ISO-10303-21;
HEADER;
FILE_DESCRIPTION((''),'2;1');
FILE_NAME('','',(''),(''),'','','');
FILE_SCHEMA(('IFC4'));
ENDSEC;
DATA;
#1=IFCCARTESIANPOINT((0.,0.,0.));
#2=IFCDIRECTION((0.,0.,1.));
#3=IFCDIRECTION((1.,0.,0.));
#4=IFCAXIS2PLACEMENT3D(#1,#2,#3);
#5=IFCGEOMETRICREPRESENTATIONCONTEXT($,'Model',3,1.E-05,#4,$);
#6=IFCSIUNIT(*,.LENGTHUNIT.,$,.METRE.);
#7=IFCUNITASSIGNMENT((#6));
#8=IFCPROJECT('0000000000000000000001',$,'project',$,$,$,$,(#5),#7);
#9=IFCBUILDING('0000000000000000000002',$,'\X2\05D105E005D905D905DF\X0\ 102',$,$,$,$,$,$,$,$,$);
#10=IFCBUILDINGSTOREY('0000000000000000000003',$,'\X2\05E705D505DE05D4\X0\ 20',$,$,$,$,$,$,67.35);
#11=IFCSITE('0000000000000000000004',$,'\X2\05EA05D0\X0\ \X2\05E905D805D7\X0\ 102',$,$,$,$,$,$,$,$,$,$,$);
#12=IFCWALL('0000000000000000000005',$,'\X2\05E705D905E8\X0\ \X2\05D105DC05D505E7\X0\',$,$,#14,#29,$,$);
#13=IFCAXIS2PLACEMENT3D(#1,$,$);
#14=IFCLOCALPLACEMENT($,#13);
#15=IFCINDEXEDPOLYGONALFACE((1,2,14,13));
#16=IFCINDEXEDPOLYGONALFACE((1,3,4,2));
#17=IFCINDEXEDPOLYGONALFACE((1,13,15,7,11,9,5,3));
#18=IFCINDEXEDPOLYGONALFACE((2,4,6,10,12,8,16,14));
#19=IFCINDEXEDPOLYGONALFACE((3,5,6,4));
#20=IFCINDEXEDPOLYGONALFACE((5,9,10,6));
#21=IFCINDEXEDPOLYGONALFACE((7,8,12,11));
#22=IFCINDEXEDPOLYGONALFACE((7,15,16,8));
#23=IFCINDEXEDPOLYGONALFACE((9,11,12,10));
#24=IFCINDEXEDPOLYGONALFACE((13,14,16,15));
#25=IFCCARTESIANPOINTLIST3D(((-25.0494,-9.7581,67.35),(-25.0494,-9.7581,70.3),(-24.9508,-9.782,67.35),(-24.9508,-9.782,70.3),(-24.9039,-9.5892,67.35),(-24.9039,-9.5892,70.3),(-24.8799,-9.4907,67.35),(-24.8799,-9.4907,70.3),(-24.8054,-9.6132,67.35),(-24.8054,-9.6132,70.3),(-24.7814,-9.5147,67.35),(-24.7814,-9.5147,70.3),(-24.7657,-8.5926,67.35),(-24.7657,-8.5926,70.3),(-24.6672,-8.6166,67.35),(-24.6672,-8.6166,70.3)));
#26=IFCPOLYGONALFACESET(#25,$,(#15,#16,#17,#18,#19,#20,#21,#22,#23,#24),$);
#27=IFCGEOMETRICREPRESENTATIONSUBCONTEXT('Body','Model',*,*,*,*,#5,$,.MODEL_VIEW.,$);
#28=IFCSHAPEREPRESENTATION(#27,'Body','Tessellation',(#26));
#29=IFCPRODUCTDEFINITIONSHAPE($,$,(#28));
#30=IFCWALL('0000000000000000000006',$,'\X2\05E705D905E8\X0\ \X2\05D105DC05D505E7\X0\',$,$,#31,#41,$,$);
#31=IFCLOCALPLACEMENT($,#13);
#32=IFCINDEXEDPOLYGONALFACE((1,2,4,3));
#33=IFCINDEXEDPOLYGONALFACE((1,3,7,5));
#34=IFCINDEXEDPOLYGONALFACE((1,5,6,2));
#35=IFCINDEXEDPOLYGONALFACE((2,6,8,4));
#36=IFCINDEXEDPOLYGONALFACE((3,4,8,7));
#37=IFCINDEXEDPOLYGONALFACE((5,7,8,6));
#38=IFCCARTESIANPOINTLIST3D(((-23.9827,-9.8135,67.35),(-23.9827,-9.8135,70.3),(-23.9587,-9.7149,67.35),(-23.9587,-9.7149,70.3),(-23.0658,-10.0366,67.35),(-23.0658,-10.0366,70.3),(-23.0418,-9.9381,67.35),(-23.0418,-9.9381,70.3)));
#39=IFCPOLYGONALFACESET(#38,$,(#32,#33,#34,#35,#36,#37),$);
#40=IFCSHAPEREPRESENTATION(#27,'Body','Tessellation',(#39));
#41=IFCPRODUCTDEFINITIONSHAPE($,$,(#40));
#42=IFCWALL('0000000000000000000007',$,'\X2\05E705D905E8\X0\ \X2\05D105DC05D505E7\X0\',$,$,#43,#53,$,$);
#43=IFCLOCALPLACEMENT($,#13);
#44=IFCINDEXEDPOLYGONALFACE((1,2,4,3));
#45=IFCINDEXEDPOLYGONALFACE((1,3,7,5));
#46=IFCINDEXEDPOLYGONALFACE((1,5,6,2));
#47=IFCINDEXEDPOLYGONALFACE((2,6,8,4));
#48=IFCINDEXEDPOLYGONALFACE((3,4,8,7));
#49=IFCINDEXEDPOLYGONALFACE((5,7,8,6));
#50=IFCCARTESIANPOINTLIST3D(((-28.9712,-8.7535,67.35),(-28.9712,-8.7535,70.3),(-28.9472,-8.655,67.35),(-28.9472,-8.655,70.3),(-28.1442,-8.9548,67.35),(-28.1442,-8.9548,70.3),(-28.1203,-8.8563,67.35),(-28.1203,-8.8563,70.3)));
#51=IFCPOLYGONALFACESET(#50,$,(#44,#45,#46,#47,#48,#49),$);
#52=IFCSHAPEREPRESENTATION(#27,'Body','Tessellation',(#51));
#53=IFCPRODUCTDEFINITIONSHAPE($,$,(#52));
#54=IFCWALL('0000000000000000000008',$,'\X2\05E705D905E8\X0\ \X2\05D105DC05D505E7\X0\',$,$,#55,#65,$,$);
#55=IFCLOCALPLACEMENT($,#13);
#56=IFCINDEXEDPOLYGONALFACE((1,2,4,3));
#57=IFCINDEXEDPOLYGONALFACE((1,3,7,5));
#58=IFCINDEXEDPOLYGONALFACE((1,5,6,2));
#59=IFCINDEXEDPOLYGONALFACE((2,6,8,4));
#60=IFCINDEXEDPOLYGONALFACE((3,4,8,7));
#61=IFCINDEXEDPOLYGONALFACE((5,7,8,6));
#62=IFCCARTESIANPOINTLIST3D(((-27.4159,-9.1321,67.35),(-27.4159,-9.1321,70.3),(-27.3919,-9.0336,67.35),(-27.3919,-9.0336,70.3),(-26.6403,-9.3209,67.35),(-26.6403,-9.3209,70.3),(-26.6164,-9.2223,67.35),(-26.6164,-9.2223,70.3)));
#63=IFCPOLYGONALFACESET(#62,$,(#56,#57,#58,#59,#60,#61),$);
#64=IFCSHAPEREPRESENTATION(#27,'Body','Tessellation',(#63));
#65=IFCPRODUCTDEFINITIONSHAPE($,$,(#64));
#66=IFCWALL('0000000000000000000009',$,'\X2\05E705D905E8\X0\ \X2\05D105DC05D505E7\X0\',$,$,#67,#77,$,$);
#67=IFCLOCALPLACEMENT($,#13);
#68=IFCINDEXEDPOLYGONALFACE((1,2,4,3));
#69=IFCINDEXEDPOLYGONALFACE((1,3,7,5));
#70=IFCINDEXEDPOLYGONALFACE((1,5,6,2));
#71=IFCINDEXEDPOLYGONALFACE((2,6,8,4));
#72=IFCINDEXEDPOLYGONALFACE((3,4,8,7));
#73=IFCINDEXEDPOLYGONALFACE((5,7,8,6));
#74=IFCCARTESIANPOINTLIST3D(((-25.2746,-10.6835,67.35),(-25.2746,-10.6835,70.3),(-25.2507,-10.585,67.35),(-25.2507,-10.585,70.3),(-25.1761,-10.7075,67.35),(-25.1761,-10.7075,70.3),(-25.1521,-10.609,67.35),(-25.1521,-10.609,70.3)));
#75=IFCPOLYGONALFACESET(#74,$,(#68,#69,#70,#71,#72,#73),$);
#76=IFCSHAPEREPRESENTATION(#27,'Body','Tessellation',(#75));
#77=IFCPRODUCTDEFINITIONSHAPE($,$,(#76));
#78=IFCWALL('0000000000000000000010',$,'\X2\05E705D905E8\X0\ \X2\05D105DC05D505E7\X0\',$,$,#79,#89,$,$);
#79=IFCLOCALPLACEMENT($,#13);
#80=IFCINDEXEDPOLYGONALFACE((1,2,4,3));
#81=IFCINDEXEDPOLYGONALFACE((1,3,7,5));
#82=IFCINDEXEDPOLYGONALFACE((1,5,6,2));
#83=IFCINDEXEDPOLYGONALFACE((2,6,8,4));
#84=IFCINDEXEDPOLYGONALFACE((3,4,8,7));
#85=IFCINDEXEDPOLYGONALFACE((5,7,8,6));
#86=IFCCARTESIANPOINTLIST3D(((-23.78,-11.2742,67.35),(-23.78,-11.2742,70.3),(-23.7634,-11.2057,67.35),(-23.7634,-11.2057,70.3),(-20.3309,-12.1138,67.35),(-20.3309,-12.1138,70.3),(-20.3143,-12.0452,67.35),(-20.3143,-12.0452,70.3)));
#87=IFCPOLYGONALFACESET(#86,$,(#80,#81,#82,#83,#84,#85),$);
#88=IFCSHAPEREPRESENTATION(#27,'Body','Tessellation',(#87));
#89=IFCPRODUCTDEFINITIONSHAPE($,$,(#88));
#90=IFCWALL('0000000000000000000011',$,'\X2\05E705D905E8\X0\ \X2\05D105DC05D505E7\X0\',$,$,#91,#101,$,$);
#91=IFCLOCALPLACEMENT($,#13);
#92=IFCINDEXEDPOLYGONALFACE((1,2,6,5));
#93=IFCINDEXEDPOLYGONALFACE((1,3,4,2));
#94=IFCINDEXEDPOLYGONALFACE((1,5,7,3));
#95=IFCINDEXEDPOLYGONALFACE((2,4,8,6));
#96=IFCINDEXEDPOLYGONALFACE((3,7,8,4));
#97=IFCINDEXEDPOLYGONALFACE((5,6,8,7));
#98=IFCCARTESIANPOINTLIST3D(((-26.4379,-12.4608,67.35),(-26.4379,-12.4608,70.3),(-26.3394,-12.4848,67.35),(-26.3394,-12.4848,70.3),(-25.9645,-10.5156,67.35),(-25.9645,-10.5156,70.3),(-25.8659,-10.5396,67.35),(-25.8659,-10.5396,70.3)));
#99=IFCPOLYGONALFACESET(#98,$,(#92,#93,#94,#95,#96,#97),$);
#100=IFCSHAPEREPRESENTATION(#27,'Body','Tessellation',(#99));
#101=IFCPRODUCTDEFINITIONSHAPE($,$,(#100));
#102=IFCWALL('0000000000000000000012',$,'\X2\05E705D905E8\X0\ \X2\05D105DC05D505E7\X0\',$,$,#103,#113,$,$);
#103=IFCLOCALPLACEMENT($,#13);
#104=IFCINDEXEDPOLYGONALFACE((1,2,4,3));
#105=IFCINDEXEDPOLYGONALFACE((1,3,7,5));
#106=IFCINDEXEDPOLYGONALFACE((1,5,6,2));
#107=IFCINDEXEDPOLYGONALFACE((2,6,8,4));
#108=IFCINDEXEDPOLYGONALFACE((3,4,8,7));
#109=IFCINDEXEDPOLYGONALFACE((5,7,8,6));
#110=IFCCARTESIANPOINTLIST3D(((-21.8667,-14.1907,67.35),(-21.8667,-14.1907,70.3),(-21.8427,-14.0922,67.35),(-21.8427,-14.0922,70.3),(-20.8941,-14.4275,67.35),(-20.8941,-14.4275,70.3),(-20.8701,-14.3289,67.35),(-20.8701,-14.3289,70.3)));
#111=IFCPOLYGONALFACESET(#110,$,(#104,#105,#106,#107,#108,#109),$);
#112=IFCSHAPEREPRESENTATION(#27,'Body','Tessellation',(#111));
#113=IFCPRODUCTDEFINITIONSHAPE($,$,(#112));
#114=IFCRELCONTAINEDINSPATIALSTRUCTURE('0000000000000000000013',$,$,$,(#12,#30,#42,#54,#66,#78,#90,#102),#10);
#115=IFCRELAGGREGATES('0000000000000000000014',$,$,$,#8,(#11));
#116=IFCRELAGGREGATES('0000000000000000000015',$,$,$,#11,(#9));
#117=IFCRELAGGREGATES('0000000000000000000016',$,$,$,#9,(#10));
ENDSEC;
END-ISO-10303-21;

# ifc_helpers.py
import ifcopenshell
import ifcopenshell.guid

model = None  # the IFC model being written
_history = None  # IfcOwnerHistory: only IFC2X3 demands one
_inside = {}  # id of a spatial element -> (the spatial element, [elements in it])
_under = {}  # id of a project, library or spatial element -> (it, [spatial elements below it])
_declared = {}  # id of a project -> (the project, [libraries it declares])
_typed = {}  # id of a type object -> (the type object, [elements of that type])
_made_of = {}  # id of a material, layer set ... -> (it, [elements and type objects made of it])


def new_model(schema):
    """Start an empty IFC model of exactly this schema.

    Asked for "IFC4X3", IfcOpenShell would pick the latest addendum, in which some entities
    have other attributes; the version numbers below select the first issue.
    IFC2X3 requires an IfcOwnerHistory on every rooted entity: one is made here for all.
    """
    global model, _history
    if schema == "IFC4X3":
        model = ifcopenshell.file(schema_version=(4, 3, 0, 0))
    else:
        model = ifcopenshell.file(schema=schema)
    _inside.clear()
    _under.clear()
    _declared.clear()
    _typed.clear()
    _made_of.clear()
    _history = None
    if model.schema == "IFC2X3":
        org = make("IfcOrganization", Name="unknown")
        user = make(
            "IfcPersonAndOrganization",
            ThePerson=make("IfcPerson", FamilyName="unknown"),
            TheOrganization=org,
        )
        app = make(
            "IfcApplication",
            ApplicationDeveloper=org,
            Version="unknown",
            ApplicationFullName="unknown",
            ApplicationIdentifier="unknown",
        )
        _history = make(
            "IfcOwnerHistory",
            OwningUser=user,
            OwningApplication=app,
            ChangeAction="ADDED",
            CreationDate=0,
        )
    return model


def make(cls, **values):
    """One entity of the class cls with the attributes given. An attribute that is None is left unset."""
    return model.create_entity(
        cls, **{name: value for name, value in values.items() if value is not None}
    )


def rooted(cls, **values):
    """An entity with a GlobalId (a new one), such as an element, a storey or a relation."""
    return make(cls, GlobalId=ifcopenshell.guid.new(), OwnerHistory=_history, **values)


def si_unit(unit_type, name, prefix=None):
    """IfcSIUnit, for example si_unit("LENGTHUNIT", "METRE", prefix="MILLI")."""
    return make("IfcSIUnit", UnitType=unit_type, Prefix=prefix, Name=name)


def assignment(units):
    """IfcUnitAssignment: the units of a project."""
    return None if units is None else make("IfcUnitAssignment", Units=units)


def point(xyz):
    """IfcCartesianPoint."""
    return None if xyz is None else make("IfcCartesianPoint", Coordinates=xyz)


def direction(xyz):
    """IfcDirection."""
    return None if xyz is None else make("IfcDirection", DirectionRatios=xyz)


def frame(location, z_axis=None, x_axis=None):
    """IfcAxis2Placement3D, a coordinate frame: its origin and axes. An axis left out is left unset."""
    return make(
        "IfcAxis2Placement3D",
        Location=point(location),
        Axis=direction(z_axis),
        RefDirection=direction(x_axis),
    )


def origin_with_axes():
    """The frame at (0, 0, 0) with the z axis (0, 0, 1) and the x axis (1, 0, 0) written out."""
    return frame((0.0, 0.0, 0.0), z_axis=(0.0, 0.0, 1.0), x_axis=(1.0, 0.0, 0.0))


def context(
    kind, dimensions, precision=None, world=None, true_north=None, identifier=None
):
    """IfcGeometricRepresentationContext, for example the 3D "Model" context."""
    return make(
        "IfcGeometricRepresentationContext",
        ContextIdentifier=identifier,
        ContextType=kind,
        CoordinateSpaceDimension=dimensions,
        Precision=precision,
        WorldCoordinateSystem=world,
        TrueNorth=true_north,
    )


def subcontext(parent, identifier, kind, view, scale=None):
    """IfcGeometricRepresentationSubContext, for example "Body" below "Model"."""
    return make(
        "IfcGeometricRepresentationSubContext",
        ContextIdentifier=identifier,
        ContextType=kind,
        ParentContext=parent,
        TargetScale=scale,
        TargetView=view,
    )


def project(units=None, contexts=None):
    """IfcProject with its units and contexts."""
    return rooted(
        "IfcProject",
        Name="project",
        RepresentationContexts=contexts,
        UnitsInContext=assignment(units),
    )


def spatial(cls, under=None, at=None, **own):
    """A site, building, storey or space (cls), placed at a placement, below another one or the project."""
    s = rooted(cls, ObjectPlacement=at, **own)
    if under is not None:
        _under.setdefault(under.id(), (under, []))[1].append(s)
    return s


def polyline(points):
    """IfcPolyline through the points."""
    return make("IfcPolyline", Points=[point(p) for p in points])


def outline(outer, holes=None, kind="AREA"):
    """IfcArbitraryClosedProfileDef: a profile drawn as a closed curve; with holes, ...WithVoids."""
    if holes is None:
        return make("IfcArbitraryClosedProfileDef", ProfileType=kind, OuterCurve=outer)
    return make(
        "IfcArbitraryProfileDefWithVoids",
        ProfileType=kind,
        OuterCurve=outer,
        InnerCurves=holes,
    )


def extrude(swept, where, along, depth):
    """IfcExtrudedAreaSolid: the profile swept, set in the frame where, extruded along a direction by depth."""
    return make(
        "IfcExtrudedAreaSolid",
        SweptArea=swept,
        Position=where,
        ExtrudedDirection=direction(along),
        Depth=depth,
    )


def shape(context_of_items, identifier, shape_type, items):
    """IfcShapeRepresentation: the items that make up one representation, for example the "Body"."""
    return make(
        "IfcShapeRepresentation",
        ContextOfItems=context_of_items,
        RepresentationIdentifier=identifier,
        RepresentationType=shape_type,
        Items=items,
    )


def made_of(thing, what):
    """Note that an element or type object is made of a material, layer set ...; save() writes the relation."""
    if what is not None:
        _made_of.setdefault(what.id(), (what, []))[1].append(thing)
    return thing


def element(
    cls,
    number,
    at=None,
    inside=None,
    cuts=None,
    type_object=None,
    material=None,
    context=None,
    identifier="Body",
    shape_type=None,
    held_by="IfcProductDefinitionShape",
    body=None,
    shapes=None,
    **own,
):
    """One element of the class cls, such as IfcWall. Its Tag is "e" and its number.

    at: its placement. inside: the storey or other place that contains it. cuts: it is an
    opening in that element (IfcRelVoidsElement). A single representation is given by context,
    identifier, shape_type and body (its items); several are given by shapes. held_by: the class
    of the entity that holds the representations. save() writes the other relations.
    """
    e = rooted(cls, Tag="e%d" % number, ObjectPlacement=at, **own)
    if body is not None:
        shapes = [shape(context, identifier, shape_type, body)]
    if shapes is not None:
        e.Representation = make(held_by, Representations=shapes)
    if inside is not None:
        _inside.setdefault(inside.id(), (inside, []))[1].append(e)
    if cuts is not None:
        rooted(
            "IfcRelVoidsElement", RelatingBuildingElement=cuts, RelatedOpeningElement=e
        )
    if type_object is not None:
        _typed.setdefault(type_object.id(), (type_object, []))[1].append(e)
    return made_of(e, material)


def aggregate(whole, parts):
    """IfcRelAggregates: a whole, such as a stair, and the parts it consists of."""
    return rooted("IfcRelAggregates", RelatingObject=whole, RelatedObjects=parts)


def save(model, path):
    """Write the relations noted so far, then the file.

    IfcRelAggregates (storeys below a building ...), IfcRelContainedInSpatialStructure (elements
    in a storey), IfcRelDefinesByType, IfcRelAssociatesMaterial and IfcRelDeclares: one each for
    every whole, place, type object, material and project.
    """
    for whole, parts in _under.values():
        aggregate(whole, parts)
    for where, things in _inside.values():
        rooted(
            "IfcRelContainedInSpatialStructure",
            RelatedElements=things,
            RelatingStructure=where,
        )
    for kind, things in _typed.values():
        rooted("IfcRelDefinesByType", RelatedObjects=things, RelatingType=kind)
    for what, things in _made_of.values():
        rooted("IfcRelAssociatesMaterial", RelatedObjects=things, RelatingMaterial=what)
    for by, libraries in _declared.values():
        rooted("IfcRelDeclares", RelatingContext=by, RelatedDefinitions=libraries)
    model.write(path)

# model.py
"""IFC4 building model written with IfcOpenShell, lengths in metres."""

from ifc_helpers import new_model, si_unit, frame, origin_with_axes, context, subcontext, project, spatial, polyline, outline, extrude, element, save


model = new_model("IFC4")

# Units and contexts
model_context = context("Model", 3, precision=1e-05, world=origin_with_axes())
body_context = subcontext(model_context, "Body", "Model", "MODEL_VIEW")
ifc_project = project(units=[si_unit("LENGTHUNIT", "METRE")], contexts=[model_context])

# Site, building, storey
site = spatial("IfcSite", under=ifc_project, Name="תא שטח 102")
building = spatial("IfcBuilding", under=site, Name="בניין 102")
storey = spatial("IfcBuildingStorey", under=building, Name="קומה 20", Elevation=67.35)

# Walls
element("IfcWall", 1, inside=storey, Name="קיר בלוק", context=body_context, shape_type="SweptSolid", body=[
    extrude(outline(polyline([(-24.8054, -9.6132), (-24.7814, -9.5147), (-24.8799, -9.4907), (-24.6672, -8.6166), (-24.7657, -8.5926), (-25.0494, -9.7581), (-24.9508, -9.782), (-24.9039, -9.5892), (-24.8054, -9.6132)])), frame((0.0, 0.0, 67.35)), (0.0, 0.0, 1.0), 2.95),
])
element("IfcWall", 2, inside=storey, Name="קיר בלוק", context=body_context, shape_type="SweptSolid", body=[
    extrude(outline(polyline([(-23.9587, -9.7149), (-23.9827, -9.8135), (-23.0658, -10.0366), (-23.0418, -9.9381), (-23.9587, -9.7149)])), frame((0.0, 0.0, 67.35)), (0.0, 0.0, 1.0), 2.95),
])
element("IfcWall", 3, inside=storey, Name="קיר בלוק", context=body_context, shape_type="SweptSolid", body=[
    extrude(outline(polyline([(-28.9712, -8.7535), (-28.1442, -8.9548), (-28.1203, -8.8563), (-28.9472, -8.655), (-28.9712, -8.7535)])), frame((0.0, 0.0, 67.35)), (0.0, 0.0, 1.0), 2.95),
])
element("IfcWall", 4, inside=storey, Name="קיר בלוק", context=body_context, shape_type="SweptSolid", body=[
    extrude(outline(polyline([(-27.3919, -9.0336), (-27.4159, -9.1321), (-26.6403, -9.3209), (-26.6164, -9.2223), (-27.3919, -9.0336)])), frame((0.0, 0.0, 67.35)), (0.0, 0.0, 1.0), 2.95),
])
element("IfcWall", 5, inside=storey, Name="קיר בלוק", context=body_context, shape_type="SweptSolid", body=[
    extrude(outline(polyline([(-25.1521, -10.609), (-25.2507, -10.585), (-25.2746, -10.6835), (-25.1761, -10.7075), (-25.1521, -10.609)])), frame((0.0, 0.0, 67.35)), (0.0, 0.0, 1.0), 2.95),
])
element("IfcWall", 6, inside=storey, Name="קיר בלוק", context=body_context, shape_type="SweptSolid", body=[
    extrude(outline(polyline([(-23.7634, -11.2057), (-23.78, -11.2742), (-20.3309, -12.1138), (-20.3143, -12.0452), (-23.7634, -11.2057)])), frame((0.0, 0.0, 67.35)), (0.0, 0.0, 1.0), 2.95),
])
element("IfcWall", 7, inside=storey, Name="קיר בלוק", context=body_context, shape_type="SweptSolid", body=[
    extrude(outline(polyline([(-26.4379, -12.4608), (-26.3394, -12.4848), (-25.8659, -10.5396), (-25.9645, -10.5156), (-26.4379, -12.4608)])), frame((0.0, 0.0, 67.35)), (0.0, 0.0, 1.0), 2.95),
])
element("IfcWall", 8, inside=storey, Name="קיר בלוק", context=body_context, shape_type="SweptSolid", body=[
    extrude(outline(polyline([(-20.8701, -14.3289), (-21.8427, -14.0922), (-21.8667, -14.1907), (-20.8941, -14.4275), (-20.8701, -14.3289)])), frame((0.0, 0.0, 67.35)), (0.0, 0.0, 1.0), 2.95),
])

save(model, "model.ifc")
